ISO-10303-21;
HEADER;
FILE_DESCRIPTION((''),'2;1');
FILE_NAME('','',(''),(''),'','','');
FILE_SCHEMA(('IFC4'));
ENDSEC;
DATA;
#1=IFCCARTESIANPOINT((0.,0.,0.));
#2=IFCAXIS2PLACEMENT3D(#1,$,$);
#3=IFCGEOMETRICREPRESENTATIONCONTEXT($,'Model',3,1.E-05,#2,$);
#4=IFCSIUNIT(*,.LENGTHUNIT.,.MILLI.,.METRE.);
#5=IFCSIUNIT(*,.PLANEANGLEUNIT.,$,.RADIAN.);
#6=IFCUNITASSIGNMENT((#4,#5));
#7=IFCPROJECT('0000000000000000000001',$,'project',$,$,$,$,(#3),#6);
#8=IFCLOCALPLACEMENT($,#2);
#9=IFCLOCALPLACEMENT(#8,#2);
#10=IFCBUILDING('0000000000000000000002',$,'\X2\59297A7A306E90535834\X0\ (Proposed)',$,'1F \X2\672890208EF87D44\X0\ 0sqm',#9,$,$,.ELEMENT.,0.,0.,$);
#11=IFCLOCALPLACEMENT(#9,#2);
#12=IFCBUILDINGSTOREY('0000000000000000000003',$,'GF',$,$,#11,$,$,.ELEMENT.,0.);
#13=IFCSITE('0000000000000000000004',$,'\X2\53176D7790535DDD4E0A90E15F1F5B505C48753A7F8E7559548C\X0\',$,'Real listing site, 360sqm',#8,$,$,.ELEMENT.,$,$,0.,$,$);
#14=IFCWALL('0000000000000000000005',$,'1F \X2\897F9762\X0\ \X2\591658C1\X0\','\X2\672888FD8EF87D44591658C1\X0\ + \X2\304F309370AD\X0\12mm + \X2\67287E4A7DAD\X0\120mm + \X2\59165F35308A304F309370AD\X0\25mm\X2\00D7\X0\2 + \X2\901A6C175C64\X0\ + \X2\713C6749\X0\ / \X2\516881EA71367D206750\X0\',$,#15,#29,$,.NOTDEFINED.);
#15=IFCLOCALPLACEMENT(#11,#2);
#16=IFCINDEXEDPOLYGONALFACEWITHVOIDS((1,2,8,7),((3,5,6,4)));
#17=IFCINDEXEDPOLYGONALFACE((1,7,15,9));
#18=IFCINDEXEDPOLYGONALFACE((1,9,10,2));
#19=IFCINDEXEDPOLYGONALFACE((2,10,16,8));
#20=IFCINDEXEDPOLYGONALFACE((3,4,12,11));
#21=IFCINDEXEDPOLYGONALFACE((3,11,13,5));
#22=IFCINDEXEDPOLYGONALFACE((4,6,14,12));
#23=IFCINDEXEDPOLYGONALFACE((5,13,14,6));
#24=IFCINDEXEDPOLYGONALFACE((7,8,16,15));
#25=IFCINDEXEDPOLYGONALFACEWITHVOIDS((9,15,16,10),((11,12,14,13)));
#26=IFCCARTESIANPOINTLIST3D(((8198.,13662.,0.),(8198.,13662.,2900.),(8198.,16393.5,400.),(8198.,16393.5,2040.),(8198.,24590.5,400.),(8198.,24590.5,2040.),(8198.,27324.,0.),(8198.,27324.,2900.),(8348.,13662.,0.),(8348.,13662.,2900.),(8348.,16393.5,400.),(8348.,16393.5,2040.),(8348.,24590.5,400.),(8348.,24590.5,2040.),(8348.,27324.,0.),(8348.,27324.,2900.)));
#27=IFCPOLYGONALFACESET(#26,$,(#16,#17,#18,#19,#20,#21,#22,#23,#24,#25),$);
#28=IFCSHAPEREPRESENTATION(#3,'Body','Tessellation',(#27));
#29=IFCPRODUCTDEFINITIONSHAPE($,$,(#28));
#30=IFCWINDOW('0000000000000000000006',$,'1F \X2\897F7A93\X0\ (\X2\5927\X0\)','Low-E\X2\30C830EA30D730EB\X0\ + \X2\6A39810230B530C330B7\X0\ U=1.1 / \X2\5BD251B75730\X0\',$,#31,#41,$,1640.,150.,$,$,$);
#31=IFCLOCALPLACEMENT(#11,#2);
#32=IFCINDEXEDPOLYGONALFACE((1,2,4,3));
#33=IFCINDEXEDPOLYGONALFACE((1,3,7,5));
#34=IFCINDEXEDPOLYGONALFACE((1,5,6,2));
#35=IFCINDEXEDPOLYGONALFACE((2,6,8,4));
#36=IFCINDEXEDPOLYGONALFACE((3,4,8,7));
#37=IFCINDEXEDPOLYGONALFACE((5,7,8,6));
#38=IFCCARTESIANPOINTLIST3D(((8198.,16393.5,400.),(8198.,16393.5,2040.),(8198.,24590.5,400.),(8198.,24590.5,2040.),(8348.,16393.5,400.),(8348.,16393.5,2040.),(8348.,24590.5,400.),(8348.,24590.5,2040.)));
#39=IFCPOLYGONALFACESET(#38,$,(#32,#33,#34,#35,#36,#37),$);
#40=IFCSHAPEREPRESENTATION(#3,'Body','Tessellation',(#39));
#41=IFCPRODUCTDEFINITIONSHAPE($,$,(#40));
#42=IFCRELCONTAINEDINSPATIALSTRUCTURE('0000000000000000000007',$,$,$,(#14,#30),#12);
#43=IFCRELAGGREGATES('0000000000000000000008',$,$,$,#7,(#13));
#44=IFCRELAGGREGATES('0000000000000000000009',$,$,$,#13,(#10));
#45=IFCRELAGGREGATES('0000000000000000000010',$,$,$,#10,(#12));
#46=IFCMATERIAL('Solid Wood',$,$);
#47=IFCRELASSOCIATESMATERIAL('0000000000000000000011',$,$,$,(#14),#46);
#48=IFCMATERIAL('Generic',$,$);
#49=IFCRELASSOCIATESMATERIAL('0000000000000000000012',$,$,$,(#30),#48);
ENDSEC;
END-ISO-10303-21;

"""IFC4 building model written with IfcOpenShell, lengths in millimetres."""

from ifc_helpers import new_model, si_unit, frame, frame_2d, origin, place, context, project, spatial, rectangle, extrude, material, element, fill, save


model = new_model("IFC4")

# Units and contexts
model_context = context("Model", 3, precision=1e-05, world=origin())
ifc_project = project(units=[si_unit("LENGTHUNIT", "METRE", prefix="MILLI"), si_unit("PLANEANGLEUNIT", "RADIAN")], contexts=[model_context])

# Site, building, storey
site_placement = place(None, origin())
site = spatial("IfcSite", under=ifc_project, at=site_placement, Name="北海道川上郡弟子屈町美留和", ObjectType="Real listing site, 360sqm", CompositionType="ELEMENT", RefElevation=0.0)
building_placement = place(site_placement, origin())
building = spatial("IfcBuilding", under=site, at=building_placement, Name="天空の道場 (Proposed)", ObjectType="1F 木造軸組 0sqm", CompositionType="ELEMENT", ElevationOfRefHeight=0.0, ElevationOfTerrain=0.0)
storey_placement = place(building_placement, origin())
storey = spatial("IfcBuildingStorey", under=building, at=storey_placement, Name="GF", CompositionType="ELEMENT", Elevation=0.0)

# Shared definitions
ifc_material_1 = material(Name="Generic")

# Shared definitions
ifc_material_2 = material(Name="Solid Wood")

# Wall, opening, window
wall_1_placement = place(storey_placement, frame((4099.0, 6831.0, 0.0)))
wall_1 = element("IfcWall", 1, at=wall_1_placement, inside=storey, material=ifc_material_2, Name="1F 西面 外壁", Description="木製軸組外壁 + くん炭12mm + 木繊維120mm + 外張りくん炭25mm×2 + 通気層 + 焼杉 / 全自然素材", PredefinedType="NOTDEFINED", context=model_context, shape_type="SweptSolid", body=[
    extrude(rectangle(XDim=150.0, YDim=13662.0, at=frame_2d((75.0, 6831.0))), frame((4099.0, 6831.0, 0.0)), (0.0, 0.0, 1.0), 2900.0),
])
opening_1_placement = place(storey_placement, frame((4099.0, 8197.0, 200.0)))
opening_1 = element("IfcOpeningElement", 2, at=opening_1_placement, cuts=wall_1, PredefinedType="NOTDEFINED", context=model_context, shape_type="SweptSolid", body=[
    extrude(rectangle(XDim=150.0, YDim=8197.0, at=frame_2d((75.0, 4098.0))), frame((4099.0, 8197.0, 200.0)), (0.0, 0.0, 1.0), 1640.0),
])
window_1_placement = place(storey_placement, frame((4099.0, 8197.0, 200.0)))
window_1 = element("IfcWindow", 3, at=window_1_placement, inside=storey, material=ifc_material_1, Name="1F 西窓 (大)", Description="Low-Eトリプル + 樹脂サッシ U=1.1 / 寒冷地", OverallHeight=1640.0, OverallWidth=150.0, context=model_context, shape_type="SweptSolid", body=[
    extrude(rectangle(XDim=150.0, YDim=8197.0, at=frame_2d((75.0, 4098.0))), frame((4099.0, 8197.0, 200.0)), (0.0, 0.0, 1.0), 1640.0),
])
fill(opening_1, window_1)

save(model, "model.ifc")
